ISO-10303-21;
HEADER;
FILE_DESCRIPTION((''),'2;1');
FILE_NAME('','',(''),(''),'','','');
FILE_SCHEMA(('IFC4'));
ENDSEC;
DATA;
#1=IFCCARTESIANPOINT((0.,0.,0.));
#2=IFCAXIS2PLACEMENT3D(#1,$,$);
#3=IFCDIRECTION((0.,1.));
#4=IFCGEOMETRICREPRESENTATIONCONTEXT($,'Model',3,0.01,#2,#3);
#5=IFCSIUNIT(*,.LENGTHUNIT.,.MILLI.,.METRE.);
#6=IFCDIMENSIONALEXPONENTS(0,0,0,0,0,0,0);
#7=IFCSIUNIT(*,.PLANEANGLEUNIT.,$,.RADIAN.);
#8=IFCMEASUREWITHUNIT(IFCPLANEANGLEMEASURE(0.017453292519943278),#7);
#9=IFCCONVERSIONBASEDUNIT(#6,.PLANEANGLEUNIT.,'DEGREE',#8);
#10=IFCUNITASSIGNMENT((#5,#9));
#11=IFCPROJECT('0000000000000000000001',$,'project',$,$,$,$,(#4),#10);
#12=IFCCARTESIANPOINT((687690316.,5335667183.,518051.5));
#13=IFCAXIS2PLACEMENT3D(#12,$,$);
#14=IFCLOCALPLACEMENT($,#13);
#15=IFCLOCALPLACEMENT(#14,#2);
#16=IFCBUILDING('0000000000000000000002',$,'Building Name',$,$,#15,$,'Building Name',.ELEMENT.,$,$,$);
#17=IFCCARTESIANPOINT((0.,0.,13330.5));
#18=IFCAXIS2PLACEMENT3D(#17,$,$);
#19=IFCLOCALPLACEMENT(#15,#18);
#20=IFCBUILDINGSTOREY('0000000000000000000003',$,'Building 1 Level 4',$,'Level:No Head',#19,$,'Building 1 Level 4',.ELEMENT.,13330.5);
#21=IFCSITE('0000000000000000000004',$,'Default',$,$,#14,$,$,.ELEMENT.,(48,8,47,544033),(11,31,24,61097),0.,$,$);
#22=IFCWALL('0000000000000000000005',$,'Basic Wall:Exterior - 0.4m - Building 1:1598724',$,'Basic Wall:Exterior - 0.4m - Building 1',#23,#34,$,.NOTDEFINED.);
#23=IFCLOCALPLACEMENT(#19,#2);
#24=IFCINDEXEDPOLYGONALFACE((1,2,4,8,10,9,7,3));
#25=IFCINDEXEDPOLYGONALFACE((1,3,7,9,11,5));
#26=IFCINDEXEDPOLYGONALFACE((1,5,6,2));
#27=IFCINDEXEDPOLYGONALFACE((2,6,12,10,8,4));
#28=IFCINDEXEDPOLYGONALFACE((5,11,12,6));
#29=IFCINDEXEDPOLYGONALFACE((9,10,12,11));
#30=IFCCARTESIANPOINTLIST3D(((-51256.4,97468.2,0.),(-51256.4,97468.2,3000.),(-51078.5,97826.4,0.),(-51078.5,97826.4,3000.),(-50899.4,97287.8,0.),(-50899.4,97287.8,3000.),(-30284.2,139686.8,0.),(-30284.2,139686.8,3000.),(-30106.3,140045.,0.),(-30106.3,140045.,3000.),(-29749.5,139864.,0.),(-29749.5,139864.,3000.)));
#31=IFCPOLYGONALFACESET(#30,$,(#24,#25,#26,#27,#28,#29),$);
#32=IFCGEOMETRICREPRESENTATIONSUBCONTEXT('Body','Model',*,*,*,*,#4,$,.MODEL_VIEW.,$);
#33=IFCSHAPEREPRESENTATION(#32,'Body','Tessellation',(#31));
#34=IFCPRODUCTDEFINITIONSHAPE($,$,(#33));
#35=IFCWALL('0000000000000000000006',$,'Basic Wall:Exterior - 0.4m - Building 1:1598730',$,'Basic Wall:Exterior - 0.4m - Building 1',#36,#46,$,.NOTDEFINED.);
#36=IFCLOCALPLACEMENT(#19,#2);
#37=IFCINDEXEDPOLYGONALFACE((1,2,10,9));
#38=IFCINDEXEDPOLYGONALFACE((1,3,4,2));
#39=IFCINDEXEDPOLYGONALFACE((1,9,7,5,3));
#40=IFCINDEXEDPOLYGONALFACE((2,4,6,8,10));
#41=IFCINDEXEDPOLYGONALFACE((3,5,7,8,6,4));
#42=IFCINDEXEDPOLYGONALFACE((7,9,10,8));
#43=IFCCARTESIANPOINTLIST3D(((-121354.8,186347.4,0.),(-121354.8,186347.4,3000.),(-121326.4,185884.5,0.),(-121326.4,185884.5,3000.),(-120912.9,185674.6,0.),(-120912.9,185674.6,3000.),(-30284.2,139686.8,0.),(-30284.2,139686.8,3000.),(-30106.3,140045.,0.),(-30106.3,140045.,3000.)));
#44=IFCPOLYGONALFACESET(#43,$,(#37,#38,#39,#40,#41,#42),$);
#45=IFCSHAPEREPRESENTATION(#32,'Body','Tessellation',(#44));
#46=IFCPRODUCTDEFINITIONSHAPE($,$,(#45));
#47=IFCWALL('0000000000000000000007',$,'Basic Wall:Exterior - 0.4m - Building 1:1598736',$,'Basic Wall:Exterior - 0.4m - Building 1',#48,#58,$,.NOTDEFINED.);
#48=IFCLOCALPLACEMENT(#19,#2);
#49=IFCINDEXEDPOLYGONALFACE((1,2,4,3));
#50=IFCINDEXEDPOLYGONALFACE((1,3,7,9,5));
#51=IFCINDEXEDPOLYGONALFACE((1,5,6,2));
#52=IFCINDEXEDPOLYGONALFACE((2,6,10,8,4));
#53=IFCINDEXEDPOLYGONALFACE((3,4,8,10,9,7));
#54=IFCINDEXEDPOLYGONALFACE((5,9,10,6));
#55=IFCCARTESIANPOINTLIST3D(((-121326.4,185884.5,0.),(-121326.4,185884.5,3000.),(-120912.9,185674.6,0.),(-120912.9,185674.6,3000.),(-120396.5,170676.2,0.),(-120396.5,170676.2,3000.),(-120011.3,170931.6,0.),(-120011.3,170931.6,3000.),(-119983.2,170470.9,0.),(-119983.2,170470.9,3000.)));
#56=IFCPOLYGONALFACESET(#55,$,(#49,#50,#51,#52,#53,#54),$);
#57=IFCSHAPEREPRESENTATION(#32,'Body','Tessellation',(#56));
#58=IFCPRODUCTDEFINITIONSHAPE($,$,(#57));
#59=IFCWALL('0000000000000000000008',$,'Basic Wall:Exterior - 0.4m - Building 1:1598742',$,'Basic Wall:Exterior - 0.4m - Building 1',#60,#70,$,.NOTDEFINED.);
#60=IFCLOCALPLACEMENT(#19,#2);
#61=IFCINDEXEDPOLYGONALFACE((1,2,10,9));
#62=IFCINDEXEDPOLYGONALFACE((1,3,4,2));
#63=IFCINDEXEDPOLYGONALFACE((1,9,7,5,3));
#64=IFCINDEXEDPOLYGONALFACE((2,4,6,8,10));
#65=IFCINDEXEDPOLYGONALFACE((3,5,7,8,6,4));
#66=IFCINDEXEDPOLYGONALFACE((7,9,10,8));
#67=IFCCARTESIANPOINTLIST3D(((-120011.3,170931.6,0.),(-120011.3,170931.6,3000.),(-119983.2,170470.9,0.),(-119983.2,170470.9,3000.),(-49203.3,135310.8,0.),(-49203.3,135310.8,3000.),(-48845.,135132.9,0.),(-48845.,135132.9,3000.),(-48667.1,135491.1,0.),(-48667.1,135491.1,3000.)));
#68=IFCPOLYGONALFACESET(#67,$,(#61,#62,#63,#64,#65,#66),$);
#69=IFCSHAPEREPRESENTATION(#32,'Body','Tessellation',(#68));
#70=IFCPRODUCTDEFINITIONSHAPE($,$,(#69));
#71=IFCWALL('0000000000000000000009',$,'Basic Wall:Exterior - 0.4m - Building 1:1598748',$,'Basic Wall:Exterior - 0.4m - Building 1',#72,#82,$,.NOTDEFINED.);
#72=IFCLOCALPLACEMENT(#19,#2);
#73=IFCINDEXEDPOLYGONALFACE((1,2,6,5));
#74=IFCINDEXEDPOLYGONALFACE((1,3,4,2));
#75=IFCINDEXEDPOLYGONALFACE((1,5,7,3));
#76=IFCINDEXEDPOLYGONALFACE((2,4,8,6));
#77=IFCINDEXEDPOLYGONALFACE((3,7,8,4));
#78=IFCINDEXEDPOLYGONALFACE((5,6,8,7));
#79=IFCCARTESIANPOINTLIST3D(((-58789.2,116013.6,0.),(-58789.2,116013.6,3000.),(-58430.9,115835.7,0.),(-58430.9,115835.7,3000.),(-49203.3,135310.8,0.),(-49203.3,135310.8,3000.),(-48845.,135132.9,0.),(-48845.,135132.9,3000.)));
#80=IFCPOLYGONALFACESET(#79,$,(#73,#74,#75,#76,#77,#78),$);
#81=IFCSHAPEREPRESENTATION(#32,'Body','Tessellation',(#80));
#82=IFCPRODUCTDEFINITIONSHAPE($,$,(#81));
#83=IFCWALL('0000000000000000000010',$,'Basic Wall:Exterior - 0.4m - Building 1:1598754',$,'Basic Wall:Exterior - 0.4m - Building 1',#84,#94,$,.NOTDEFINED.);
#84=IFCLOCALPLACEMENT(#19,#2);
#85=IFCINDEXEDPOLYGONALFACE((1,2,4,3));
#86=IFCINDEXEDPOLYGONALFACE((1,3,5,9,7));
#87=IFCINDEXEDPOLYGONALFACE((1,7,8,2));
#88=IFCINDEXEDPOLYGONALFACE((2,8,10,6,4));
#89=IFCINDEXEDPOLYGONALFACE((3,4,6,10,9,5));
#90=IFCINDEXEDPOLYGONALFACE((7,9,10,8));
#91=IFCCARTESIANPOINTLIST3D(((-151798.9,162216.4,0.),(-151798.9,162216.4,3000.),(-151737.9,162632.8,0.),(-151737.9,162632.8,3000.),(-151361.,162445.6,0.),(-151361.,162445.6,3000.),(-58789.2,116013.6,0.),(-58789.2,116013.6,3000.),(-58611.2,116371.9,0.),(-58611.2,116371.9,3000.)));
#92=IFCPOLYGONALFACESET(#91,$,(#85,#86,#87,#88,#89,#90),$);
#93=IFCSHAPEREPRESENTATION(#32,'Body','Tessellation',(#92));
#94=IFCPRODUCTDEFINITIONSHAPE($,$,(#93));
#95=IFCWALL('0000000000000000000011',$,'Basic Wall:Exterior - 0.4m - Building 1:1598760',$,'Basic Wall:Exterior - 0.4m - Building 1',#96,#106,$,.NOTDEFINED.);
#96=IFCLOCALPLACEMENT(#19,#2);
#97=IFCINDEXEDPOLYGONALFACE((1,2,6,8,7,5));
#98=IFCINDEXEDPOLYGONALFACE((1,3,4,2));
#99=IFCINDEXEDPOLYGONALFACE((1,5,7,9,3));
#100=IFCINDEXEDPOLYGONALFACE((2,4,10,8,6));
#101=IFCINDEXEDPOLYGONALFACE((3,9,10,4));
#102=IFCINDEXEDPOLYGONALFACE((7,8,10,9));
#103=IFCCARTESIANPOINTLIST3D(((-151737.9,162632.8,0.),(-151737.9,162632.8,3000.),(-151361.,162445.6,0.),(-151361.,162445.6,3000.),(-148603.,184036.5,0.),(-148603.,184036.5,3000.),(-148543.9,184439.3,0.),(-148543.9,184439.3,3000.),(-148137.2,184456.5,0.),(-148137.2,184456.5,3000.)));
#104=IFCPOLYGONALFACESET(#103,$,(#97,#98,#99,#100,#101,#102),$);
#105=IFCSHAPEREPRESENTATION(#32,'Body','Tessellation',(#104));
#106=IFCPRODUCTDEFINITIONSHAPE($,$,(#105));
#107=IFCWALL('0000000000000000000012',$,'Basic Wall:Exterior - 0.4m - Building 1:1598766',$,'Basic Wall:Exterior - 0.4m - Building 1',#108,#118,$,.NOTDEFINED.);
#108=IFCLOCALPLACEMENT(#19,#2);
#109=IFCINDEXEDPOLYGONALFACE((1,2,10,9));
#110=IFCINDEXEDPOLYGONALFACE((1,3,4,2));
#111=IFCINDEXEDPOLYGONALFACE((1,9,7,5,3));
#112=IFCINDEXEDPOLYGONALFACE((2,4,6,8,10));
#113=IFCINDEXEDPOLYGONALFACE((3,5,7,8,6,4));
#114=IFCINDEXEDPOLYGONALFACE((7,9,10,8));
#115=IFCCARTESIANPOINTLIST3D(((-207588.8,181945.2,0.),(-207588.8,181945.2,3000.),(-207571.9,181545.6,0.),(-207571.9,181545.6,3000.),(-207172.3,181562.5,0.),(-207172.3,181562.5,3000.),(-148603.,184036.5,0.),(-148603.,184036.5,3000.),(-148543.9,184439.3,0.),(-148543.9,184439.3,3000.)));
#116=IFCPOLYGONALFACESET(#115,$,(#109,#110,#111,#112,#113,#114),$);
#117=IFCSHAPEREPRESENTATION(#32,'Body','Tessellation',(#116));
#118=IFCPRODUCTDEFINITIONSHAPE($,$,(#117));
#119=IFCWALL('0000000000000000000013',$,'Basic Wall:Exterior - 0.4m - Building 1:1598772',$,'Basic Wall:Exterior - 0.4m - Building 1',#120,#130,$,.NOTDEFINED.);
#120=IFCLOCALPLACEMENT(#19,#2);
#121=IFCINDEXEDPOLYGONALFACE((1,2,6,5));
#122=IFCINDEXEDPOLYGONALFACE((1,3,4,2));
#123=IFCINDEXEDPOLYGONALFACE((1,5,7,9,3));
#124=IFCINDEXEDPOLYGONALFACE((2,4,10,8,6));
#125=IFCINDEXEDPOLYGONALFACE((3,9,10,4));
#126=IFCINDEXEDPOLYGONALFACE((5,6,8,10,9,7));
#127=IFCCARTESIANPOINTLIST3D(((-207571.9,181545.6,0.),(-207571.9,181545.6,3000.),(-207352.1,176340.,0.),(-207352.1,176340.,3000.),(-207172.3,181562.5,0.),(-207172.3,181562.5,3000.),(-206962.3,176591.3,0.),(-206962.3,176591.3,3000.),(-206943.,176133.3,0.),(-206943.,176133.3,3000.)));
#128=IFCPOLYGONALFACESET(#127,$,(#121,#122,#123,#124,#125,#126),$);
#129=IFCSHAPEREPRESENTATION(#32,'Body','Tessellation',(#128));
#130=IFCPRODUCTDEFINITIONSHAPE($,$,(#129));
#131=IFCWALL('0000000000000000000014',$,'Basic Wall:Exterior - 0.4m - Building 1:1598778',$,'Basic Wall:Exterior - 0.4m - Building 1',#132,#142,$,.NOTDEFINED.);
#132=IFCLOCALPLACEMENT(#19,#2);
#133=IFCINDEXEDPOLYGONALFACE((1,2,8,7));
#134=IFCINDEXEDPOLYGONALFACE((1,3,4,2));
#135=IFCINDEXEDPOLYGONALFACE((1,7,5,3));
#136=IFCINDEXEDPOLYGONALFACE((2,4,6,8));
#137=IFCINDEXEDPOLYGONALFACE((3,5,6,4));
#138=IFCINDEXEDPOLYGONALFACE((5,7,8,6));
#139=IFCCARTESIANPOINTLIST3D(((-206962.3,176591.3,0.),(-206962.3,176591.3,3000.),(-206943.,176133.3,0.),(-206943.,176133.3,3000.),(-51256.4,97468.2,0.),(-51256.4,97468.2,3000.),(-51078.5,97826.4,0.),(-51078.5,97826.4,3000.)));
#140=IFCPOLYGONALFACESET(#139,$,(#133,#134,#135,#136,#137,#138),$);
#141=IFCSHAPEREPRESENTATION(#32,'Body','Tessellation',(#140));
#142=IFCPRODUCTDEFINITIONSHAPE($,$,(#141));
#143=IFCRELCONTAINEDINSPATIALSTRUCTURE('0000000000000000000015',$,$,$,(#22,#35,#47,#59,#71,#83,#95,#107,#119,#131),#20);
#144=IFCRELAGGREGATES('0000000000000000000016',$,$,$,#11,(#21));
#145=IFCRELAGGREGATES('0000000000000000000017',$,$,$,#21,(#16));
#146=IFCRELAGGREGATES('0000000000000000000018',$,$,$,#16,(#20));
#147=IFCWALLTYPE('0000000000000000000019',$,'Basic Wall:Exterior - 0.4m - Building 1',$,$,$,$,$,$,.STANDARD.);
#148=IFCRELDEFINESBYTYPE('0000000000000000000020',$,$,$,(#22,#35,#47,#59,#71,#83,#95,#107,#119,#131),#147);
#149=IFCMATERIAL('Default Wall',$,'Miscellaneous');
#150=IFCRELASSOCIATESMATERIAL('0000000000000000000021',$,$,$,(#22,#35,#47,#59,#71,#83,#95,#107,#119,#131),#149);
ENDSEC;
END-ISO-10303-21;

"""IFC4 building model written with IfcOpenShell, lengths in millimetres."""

from ifc_helpers import new_model, entity, si_unit, converted_unit, direction, frame, origin, place, context, subcontext, project, spatial, indexed_curve, outline, extrude, material, type_object, element, save


model = new_model("IFC4")

# Units and contexts
model_context = context("Model", 3, precision=0.01, world=origin(), true_north=direction((0.0, 1.0)))
body_context = subcontext(model_context, "Body", "Model", "MODEL_VIEW")
ifc_project = project(units=[si_unit("LENGTHUNIT", "METRE", prefix="MILLI"), converted_unit("PLANEANGLEUNIT", "DEGREE", entity("IfcPlaneAngleMeasure", 0.017453292519943278), si_unit("PLANEANGLEUNIT", "RADIAN"), dimensions=[0, 0, 0, 0, 0, 0, 0])], contexts=[model_context])

# Site, building, storey
site_placement = place(None, frame((687690316.0, 5335667183.0, 518051.5)))
site = spatial("IfcSite", under=ifc_project, at=site_placement, Name="Default", CompositionType="ELEMENT", RefLatitude=(48, 8, 47, 544033), RefLongitude=(11, 31, 24, 61097), RefElevation=0.0)
building_placement = place(site_placement, origin())
building = spatial("IfcBuilding", under=site, at=building_placement, Name="Building Name", LongName="Building Name", CompositionType="ELEMENT")
storey_placement = place(building_placement, frame((0.0, 0.0, 13330.5)))
storey = spatial("IfcBuildingStorey", under=building, at=storey_placement, Name="Building 1 Level 4", ObjectType="Level:No Head", LongName="Building 1 Level 4", CompositionType="ELEMENT", Elevation=13330.5)

# Walls
ifc_material_1 = material(Name="Default Wall", Category="Miscellaneous")
wall_type = type_object("IfcWallType", Name="Basic Wall:Exterior - 0.4m - Building 1", PredefinedType="STANDARD")
wall_1_placement = place(storey_placement, frame((-51078.5, 97376.7, 0.0), z_axis=(0.0, 0.0, 1.0), x_axis=(0.444885, 0.895588, 0.0)))
element("IfcWall", 1, at=wall_1_placement, inside=storey, type_object=wall_type, material=ifc_material_1, Name="Basic Wall:Exterior - 0.4m - Building 1:1598724", ObjectType="Basic Wall:Exterior - 0.4m - Building 1", PredefinedType="NOTDEFINED", context=body_context, shape_type="SweptSolid", body=[
    extrude(outline(indexed_curve([(47540.0, -200.0), (47543.5, 200.0), (47143.4, 200.0), (402.7, 200.0), (2.7, 200.0), (0.0, -200.0), (47540.0, -200.0)], self_intersect=False)), origin(), (0.0, 0.0, 1.0), 3000.0),
])
wall_2_placement = place(storey_placement, frame((-30193.7, 139865.1, 0.0), z_axis=(0.0, 0.0, 1.0), x_axis=(-0.891761, 0.452507, 0.0)))
element("IfcWall", 2, at=wall_2_placement, inside=storey, type_object=wall_type, material=ifc_material_1, Name="Basic Wall:Exterior - 0.4m - Building 1:1598730", ObjectType="Basic Wall:Exterior - 0.4m - Building 1", PredefinedType="NOTDEFINED", context=body_context, shape_type="SweptSolid", body=[
    extrude(outline(indexed_curve([(102327.4, -200.0), (102092.7, 200.0), (101628.9, 200.0), (0.0, 200.0), (3.4, -200.0), (102327.4, -200.0)], self_intersect=False)), origin(), (0.0, 0.0, 1.0), 3000.0),
])
wall_3_placement = place(storey_placement, frame((-121126.8, 185896.7, 0.0), z_axis=(0.0, 0.0, 1.0), x_axis=(0.061037, -0.998136, 0.0)))
element("IfcWall", 3, at=wall_3_placement, inside=storey, type_object=wall_type, material=ifc_material_1, Name="Basic Wall:Exterior - 0.4m - Building 1:1598736", ObjectType="Basic Wall:Exterior - 0.4m - Building 1", PredefinedType="NOTDEFINED", context=body_context, shape_type="SweptSolid", body=[
    extrude(outline(indexed_curve([(15236.7, -200.0), (15466.8, 200.0), (15005.3, 200.0), (234.7, 200.0), (0.0, -200.0), (15236.7, -200.0)], self_intersect=False)), origin(), (0.0, 0.0, 1.0), 3000.0),
])
wall_4_placement = place(storey_placement, frame((-120100.3, 170752.4, 0.0), z_axis=(0.0, 0.0, 1.0), x_axis=(0.895588, -0.444885, 0.0)))
element("IfcWall", 4, at=wall_4_placement, inside=storey, type_object=wall_type, material=ifc_material_1, Name="Basic Wall:Exterior - 0.4m - Building 1:1598742", ObjectType="Basic Wall:Exterior - 0.4m - Building 1", PredefinedType="NOTDEFINED", context=body_context, shape_type="SweptSolid", body=[
    extrude(outline(indexed_curve([(79662.0, -200.0), (79662.0, 200.0), (0.0, 200.0), (230.2, -200.0), (79262.0, -200.0), (79662.0, -200.0)], self_intersect=False)), origin(), (0.0, 0.0, 1.0), 3000.0),
])
wall_5_placement = place(storey_placement, frame((-49024.1, 135221.9, 0.0), z_axis=(0.0, 0.0, 1.0), x_axis=(-0.444885, -0.895588, 0.0)))
element("IfcWall", 5, at=wall_5_placement, inside=storey, type_object=wall_type, material=ifc_material_1, Name="Basic Wall:Exterior - 0.4m - Building 1:1598748", ObjectType="Basic Wall:Exterior - 0.4m - Building 1", PredefinedType="NOTDEFINED", context=body_context, shape_type="SweptSolid", body=[
    extrude(outline(indexed_curve([(21547.0, 200.0), (0.0, 200.0), (0.0, -200.0), (21547.0, -200.0), (21547.0, 200.0)], self_intersect=False)), origin(), (0.0, 0.0, 1.0), 3000.0),
])
wall_6_placement = place(storey_placement, frame((-58700.2, 116192.8, 0.0), z_axis=(0.0, 0.0, 1.0), x_axis=(-0.895588, 0.444885, 0.0)))
element("IfcWall", 6, at=wall_6_placement, inside=storey, type_object=wall_type, material=ifc_material_1, Name="Basic Wall:Exterior - 0.4m - Building 1:1598754", ObjectType="Basic Wall:Exterior - 0.4m - Building 1", PredefinedType="NOTDEFINED", context=body_context, shape_type="SweptSolid", body=[
    extrude(outline(indexed_curve([(103983.9, -200.0), (103853.3, 200.0), (0.0, 200.0), (0.0, -200.0), (103563.1, -200.0), (103983.9, -200.0)], self_intersect=False)), origin(), (0.0, 0.0, 1.0), 3000.0),
])
wall_7_placement = place(storey_placement, frame((-151558.9, 162474.6, 0.0), z_axis=(0.0, 0.0, 1.0), x_axis=(0.144921, 0.989443, 0.0)))
element("IfcWall", 7, at=wall_7_placement, inside=storey, type_object=wall_type, material=ifc_material_1, Name="Basic Wall:Exterior - 0.4m - Building 1:1598760", ObjectType="Basic Wall:Exterior - 0.4m - Building 1", PredefinedType="NOTDEFINED", context=body_context, shape_type="SweptSolid", body=[
    extrude(outline(indexed_curve([(22245.8, -200.0), (22169.8, 200.0), (21762.7, 200.0), (130.6, 200.0), (0.0, -200.0), (22245.8, -200.0)], self_intersect=False)), origin(), (0.0, 0.0, 1.0), 3000.0),
])
wall_8_placement = place(storey_placement, frame((-148535.5, 184239.5, 0.0), z_axis=(0.0, 0.0, 1.0), x_axis=(-0.999109, -0.042203, 0.0)))
element("IfcWall", 8, at=wall_8_placement, inside=storey, type_object=wall_type, material=ifc_material_1, Name="Basic Wall:Exterior - 0.4m - Building 1:1598766", ObjectType="Basic Wall:Exterior - 0.4m - Building 1", PredefinedType="NOTDEFINED", context=body_context, shape_type="SweptSolid", body=[
    extrude(outline(indexed_curve([(59097.5, -200.0), (59097.5, 200.0), (58697.5, 200.0), (76.0, 200.0), (0.0, -200.0), (59097.5, -200.0)], self_intersect=False)), origin(), (0.0, 0.0, 1.0), 3000.0),
])
wall_9_placement = place(storey_placement, frame((-207372.1, 181554.0, 0.0), z_axis=(0.0, 0.0, 1.0), x_axis=(0.042203, -0.999109, 0.0)))
element("IfcWall", 9, at=wall_9_placement, inside=storey, type_object=wall_type, material=ifc_material_1, Name="Basic Wall:Exterior - 0.4m - Building 1:1598772", ObjectType="Basic Wall:Exterior - 0.4m - Building 1", PredefinedType="NOTDEFINED", context=body_context, shape_type="SweptSolid", body=[
    extrude(outline(indexed_curve([(5210.2, -200.0), (5434.0, 200.0), (4975.6, 200.0), (0.0, 200.0), (0.0, -200.0), (5210.2, -200.0)], self_intersect=False)), origin(), (0.0, 0.0, 1.0), 3000.0),
])
wall_10_placement = place(storey_placement, frame((-207052.5, 176412.8, 0.0), z_axis=(0.0, 0.0, 1.0), x_axis=(0.892534, -0.450979, 0.0)))
element("IfcWall", 10, at=wall_10_placement, inside=storey, type_object=wall_type, material=ifc_material_1, Name="Basic Wall:Exterior - 0.4m - Building 1:1598778", ObjectType="Basic Wall:Exterior - 0.4m - Building 1", PredefinedType="NOTDEFINED", context=body_context, shape_type="SweptSolid", body=[
    extrude(outline(indexed_curve([(174655.7, -200.0), (174653.0, 200.0), (0.0, 200.0), (223.8, -200.0), (174655.7, -200.0)], self_intersect=False)), origin(), (0.0, 0.0, 1.0), 3000.0),
])

save(model, "model.ifc")
